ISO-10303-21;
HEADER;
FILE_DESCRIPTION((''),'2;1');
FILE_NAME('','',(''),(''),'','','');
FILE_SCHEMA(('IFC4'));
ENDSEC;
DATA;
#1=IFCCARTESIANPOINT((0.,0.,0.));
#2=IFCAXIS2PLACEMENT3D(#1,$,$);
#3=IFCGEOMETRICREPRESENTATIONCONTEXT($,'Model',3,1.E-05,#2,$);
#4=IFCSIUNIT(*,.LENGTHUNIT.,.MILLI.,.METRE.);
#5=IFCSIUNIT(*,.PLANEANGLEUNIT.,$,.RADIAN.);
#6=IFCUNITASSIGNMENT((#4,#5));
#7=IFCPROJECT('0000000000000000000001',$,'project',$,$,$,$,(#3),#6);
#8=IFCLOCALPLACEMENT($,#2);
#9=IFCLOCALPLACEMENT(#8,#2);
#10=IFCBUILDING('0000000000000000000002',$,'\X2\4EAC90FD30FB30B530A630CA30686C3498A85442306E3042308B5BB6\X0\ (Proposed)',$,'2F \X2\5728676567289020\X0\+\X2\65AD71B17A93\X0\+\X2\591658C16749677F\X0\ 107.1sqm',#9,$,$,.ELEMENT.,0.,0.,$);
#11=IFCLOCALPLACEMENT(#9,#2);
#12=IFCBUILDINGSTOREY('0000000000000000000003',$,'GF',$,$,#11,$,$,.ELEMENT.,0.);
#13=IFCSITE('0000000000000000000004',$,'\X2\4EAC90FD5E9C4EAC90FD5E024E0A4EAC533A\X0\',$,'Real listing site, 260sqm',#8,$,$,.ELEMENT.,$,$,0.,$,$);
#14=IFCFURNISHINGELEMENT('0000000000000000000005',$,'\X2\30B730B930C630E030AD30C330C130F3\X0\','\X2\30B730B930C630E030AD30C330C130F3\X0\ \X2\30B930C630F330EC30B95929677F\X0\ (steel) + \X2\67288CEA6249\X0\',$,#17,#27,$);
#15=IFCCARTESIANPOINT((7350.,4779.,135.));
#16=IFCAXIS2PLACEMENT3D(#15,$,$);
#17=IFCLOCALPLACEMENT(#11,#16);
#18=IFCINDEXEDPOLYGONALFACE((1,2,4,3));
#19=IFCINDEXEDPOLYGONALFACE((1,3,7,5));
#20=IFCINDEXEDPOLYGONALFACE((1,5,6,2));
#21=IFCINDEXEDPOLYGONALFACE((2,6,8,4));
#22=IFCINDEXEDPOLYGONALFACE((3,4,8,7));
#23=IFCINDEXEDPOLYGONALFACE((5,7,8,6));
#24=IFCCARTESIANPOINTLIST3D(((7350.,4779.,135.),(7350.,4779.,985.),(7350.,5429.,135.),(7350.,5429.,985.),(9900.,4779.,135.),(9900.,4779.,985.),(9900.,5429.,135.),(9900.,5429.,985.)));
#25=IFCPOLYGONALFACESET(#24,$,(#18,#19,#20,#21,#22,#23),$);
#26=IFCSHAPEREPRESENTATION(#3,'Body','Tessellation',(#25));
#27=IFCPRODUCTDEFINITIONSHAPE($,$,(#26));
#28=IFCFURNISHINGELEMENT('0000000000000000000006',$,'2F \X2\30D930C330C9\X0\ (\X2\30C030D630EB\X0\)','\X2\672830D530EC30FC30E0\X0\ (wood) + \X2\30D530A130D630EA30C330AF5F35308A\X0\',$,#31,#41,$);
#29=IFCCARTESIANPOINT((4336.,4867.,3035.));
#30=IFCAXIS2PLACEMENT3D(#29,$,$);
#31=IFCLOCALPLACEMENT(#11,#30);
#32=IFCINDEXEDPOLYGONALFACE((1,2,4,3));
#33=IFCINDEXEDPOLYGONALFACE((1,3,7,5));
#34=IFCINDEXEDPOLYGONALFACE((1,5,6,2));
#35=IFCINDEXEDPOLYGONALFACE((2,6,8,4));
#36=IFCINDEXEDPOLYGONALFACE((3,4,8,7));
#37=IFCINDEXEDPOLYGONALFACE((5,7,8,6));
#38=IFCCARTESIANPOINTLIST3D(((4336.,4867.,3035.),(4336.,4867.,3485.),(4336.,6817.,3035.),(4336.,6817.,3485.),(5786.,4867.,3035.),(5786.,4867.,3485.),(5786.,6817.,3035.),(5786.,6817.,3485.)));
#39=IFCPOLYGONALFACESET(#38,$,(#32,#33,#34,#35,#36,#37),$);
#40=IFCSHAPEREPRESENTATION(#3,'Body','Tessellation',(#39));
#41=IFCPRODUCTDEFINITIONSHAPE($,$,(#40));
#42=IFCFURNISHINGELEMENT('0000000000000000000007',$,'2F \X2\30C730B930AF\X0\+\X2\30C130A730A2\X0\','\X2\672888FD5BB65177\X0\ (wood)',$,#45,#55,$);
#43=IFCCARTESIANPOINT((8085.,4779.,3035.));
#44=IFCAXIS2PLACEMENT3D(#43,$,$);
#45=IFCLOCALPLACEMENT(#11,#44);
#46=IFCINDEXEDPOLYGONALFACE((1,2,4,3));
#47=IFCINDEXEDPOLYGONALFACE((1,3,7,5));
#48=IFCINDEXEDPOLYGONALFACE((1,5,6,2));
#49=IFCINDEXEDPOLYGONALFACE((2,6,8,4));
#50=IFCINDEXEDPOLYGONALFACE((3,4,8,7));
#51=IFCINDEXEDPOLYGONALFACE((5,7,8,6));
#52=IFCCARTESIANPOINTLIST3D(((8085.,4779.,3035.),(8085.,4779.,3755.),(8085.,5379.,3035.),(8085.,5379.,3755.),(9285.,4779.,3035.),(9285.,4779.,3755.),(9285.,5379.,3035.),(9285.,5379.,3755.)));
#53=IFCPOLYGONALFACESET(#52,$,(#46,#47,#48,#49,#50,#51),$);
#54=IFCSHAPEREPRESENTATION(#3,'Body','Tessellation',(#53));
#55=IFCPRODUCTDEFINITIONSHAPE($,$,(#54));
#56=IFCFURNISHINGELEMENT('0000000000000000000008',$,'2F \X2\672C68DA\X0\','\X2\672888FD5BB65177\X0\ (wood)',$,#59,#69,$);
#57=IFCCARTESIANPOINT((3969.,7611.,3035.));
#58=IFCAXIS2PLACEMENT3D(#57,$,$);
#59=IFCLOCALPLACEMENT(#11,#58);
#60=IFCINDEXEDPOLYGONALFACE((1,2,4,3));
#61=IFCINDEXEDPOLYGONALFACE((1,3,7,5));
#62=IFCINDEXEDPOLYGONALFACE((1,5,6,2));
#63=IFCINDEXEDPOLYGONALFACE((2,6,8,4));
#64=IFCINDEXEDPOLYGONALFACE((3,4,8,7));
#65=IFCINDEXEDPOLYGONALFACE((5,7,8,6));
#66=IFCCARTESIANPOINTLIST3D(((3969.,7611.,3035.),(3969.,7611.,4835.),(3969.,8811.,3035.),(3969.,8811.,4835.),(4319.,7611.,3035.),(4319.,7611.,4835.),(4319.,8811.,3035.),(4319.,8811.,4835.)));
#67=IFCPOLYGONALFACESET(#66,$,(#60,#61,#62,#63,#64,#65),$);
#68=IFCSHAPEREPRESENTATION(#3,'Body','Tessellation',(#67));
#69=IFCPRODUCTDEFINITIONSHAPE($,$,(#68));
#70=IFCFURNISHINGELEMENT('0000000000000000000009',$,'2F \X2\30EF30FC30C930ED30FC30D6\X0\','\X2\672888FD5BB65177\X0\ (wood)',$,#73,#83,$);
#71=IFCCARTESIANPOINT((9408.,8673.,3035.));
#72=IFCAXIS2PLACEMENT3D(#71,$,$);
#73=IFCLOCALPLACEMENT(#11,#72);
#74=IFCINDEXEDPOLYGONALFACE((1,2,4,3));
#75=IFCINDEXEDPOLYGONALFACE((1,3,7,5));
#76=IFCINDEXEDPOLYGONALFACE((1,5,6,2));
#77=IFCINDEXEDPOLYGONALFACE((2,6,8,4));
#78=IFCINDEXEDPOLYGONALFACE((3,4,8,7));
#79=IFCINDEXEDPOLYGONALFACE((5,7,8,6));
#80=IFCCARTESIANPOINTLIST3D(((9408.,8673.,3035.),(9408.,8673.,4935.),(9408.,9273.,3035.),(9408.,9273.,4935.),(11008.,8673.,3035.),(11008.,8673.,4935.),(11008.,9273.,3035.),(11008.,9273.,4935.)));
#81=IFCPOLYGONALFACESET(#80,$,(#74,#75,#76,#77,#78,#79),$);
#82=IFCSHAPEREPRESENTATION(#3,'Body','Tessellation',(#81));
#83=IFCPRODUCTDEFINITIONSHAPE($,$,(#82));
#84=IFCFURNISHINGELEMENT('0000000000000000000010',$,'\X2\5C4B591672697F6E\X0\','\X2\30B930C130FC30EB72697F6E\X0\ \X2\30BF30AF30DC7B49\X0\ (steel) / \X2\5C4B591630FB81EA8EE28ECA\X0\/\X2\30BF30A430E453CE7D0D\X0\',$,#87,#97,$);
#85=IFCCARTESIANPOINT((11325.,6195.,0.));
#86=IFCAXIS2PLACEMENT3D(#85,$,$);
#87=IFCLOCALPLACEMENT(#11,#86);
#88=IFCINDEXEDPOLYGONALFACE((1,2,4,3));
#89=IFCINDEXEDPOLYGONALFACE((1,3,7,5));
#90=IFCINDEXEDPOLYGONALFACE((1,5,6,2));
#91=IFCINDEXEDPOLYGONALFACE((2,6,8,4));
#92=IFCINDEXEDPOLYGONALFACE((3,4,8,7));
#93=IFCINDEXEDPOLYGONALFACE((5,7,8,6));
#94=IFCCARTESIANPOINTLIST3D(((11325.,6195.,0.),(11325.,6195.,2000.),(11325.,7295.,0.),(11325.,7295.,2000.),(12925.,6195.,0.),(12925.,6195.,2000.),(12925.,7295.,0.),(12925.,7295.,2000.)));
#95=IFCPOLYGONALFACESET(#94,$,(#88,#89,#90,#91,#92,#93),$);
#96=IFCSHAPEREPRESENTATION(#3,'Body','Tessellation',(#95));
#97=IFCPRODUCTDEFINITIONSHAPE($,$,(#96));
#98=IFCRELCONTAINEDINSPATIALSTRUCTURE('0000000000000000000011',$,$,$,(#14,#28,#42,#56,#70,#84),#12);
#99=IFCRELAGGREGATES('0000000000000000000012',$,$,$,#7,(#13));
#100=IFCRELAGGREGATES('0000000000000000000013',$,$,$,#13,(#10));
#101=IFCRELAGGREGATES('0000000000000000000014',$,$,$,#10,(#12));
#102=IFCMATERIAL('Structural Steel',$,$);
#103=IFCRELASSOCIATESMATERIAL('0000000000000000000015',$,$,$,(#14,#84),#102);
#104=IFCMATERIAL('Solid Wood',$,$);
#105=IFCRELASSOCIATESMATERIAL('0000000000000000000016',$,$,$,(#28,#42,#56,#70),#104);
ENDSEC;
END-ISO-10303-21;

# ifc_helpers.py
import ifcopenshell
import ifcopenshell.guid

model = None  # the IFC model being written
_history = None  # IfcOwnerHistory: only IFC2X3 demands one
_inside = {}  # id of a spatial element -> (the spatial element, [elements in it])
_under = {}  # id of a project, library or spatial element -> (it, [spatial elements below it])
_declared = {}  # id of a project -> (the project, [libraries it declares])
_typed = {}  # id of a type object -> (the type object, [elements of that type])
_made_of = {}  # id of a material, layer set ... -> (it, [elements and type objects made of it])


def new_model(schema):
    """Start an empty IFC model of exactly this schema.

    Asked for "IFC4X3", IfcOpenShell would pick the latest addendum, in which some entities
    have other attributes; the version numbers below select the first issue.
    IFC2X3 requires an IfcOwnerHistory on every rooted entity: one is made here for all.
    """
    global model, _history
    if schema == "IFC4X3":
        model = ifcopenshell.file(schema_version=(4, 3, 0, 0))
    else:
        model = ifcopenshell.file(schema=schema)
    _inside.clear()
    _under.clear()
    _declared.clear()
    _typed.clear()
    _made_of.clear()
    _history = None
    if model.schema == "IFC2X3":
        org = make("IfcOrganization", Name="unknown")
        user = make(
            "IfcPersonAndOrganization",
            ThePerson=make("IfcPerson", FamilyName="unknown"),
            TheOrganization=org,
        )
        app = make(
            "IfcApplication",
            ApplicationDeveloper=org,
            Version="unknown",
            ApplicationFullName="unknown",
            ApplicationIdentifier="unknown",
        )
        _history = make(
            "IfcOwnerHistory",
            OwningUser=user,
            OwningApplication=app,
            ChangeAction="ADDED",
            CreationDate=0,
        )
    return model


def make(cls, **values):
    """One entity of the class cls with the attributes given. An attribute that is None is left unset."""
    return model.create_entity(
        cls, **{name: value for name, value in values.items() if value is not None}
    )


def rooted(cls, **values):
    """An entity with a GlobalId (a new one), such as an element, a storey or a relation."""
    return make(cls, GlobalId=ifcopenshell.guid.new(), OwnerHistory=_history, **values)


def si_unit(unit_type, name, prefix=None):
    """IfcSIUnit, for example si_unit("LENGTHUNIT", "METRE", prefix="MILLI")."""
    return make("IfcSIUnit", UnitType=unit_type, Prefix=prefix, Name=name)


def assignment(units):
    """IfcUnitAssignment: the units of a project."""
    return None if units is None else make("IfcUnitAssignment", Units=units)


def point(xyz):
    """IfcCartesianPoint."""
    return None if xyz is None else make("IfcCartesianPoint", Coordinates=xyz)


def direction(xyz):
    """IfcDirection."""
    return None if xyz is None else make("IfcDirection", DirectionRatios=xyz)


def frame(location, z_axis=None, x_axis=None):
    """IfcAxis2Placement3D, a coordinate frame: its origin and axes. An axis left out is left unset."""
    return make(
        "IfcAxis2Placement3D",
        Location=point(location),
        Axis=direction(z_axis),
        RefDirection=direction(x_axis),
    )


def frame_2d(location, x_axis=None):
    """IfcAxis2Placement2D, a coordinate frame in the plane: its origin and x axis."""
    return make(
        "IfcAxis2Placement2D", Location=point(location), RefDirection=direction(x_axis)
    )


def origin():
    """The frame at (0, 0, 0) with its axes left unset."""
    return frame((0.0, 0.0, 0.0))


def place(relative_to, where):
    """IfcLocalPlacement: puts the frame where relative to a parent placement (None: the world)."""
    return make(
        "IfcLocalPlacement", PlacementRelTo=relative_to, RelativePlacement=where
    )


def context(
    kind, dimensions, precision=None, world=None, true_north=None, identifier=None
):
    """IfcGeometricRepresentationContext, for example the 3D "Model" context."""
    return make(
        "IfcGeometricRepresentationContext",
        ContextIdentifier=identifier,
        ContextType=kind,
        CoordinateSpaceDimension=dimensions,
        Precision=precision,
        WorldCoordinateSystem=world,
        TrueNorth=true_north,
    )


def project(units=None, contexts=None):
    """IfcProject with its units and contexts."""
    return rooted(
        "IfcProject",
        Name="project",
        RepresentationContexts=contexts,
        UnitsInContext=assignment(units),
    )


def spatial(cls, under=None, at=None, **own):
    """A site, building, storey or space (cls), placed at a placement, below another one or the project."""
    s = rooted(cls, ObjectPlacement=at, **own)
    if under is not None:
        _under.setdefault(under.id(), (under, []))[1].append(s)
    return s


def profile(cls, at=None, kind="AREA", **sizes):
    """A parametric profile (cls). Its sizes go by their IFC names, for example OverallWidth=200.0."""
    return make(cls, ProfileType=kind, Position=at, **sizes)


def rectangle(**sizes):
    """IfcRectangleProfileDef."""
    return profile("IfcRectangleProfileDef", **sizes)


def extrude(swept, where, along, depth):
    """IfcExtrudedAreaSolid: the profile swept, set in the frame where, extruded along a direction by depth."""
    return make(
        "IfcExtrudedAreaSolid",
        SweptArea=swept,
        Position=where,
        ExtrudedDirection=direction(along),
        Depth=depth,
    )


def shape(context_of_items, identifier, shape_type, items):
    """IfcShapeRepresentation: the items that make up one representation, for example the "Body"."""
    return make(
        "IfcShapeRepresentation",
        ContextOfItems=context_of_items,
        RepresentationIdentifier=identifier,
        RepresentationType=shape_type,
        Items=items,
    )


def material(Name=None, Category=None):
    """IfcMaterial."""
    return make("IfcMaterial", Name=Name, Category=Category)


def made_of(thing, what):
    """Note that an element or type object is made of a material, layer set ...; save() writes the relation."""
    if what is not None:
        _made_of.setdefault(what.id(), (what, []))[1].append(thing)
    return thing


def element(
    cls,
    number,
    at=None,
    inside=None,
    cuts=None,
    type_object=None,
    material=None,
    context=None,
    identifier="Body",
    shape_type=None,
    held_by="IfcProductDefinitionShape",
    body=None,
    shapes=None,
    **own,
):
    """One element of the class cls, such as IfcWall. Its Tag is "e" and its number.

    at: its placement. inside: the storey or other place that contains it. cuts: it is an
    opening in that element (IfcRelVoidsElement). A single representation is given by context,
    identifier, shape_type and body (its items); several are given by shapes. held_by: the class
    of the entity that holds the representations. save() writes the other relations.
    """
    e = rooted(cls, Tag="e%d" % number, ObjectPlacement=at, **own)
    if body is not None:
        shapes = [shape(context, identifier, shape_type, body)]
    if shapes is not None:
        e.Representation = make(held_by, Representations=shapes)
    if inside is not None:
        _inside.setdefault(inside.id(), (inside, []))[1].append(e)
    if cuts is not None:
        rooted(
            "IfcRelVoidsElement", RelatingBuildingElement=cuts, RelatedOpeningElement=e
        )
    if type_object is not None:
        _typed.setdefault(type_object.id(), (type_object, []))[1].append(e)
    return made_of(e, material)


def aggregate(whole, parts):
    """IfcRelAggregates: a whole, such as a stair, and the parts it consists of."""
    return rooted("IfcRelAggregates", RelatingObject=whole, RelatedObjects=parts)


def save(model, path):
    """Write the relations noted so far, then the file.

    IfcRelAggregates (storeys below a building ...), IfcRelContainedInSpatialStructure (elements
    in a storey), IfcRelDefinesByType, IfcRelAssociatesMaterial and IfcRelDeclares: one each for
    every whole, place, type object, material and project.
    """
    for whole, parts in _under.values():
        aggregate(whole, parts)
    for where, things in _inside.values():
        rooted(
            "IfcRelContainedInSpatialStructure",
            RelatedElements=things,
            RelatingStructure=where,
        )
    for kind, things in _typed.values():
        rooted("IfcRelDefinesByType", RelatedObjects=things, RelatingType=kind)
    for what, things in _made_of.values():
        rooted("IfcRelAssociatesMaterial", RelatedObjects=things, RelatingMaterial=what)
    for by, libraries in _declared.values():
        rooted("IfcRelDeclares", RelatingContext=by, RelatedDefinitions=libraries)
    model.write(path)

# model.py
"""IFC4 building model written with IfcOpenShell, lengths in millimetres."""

from ifc_helpers import new_model, si_unit, frame, frame_2d, origin, place, context, project, spatial, rectangle, extrude, material, element, save


model = new_model("IFC4")

# Units and contexts
model_context = context("Model", 3, precision=1e-05, world=origin())
ifc_project = project(units=[si_unit("LENGTHUNIT", "METRE", prefix="MILLI"), si_unit("PLANEANGLEUNIT", "RADIAN")], contexts=[model_context])

# Site, building, storey
site_placement = place(None, origin())
site = spatial("IfcSite", under=ifc_project, at=site_placement, Name="京都府京都市上京区", ObjectType="Real listing site, 260sqm", CompositionType="ELEMENT", RefElevation=0.0)
building_placement = place(site_placement, origin())
building = spatial("IfcBuilding", under=site, at=building_placement, Name="京都・サウナと水風呂のある家 (Proposed)", ObjectType="2F 在来木造+断熱窓+外壁杉板 107.1sqm", CompositionType="ELEMENT", ElevationOfRefHeight=0.0, ElevationOfTerrain=0.0)
storey_placement = place(building_placement, origin())
storey = spatial("IfcBuildingStorey", under=building, at=storey_placement, Name="GF", CompositionType="ELEMENT", Elevation=0.0)

# Shared definitions
ifc_material_1 = material(Name="Solid Wood")

# Shared definitions
ifc_material_2 = material(Name="Structural Steel")

# Furnishing elements
furnishing_1_placement = place(storey_placement, frame((7350.0, 4779.0, 135.0)))
element("IfcFurnishingElement", 1, at=furnishing_1_placement, inside=storey, material=ifc_material_2, Name="システムキッチン", Description="システムキッチン ステンレス天板 (steel) + 木質扉", context=model_context, shape_type="SweptSolid", body=[
    extrude(rectangle(XDim=2550.0, YDim=650.0, at=frame_2d((1275.0, 325.0))), frame((7350.0, 4779.0, 135.0)), (0.0, 0.0, 1.0), 850.0),
])
furnishing_2_placement = place(storey_placement, frame((4336.0, 4867.0, 3035.0)))
element("IfcFurnishingElement", 2, at=furnishing_2_placement, inside=storey, material=ifc_material_1, Name="2F ベッド (ダブル)", Description="木フレーム (wood) + ファブリック張り", context=model_context, shape_type="SweptSolid", body=[
    extrude(rectangle(XDim=1450.0, YDim=1950.0, at=frame_2d((725.0, 975.0))), frame((4336.0, 4867.0, 3035.0)), (0.0, 0.0, 1.0), 450.0),
])
furnishing_3_placement = place(storey_placement, frame((8085.0, 4779.0, 3035.0)))
element("IfcFurnishingElement", 3, at=furnishing_3_placement, inside=storey, material=ifc_material_1, Name="2F デスク+チェア", Description="木製家具 (wood)", context=model_context, shape_type="SweptSolid", body=[
    extrude(rectangle(XDim=1200.0, YDim=600.0, at=frame_2d((600.0, 300.0))), frame((8085.0, 4779.0, 3035.0)), (0.0, 0.0, 1.0), 720.0),
])
furnishing_4_placement = place(storey_placement, frame((3969.0, 7611.0, 3035.0)))
element("IfcFurnishingElement", 4, at=furnishing_4_placement, inside=storey, material=ifc_material_1, Name="2F 本棚", Description="木製家具 (wood)", context=model_context, shape_type="SweptSolid", body=[
    extrude(rectangle(XDim=350.0, YDim=1200.0, at=frame_2d((175.0, 600.0))), frame((3969.0, 7611.0, 3035.0)), (0.0, 0.0, 1.0), 1800.0),
])
furnishing_5_placement = place(storey_placement, frame((9408.0, 8673.0, 3035.0)))
element("IfcFurnishingElement", 5, at=furnishing_5_placement, inside=storey, material=ifc_material_1, Name="2F ワードローブ", Description="木製家具 (wood)", context=model_context, shape_type="SweptSolid", body=[
    extrude(rectangle(XDim=1600.0, YDim=600.0, at=frame_2d((800.0, 300.0))), frame((9408.0, 8673.0, 3035.0)), (0.0, 0.0, 1.0), 1900.0),
])
furnishing_6_placement = place(storey_placement, frame((11325.0, 6195.0, 0.0)))
element("IfcFurnishingElement", 6, at=furnishing_6_placement, inside=storey, material=ifc_material_2, Name="屋外物置", Description="スチール物置 タクボ等 (steel) / 屋外・自転車/タイヤ収納", context=model_context, shape_type="SweptSolid", body=[
    extrude(rectangle(XDim=1600.0, YDim=1100.0, at=frame_2d((800.0, 550.0))), frame((11325.0, 6195.0, 0.0)), (0.0, 0.0, 1.0), 2000.0),
])

save(model, "model.ifc")
